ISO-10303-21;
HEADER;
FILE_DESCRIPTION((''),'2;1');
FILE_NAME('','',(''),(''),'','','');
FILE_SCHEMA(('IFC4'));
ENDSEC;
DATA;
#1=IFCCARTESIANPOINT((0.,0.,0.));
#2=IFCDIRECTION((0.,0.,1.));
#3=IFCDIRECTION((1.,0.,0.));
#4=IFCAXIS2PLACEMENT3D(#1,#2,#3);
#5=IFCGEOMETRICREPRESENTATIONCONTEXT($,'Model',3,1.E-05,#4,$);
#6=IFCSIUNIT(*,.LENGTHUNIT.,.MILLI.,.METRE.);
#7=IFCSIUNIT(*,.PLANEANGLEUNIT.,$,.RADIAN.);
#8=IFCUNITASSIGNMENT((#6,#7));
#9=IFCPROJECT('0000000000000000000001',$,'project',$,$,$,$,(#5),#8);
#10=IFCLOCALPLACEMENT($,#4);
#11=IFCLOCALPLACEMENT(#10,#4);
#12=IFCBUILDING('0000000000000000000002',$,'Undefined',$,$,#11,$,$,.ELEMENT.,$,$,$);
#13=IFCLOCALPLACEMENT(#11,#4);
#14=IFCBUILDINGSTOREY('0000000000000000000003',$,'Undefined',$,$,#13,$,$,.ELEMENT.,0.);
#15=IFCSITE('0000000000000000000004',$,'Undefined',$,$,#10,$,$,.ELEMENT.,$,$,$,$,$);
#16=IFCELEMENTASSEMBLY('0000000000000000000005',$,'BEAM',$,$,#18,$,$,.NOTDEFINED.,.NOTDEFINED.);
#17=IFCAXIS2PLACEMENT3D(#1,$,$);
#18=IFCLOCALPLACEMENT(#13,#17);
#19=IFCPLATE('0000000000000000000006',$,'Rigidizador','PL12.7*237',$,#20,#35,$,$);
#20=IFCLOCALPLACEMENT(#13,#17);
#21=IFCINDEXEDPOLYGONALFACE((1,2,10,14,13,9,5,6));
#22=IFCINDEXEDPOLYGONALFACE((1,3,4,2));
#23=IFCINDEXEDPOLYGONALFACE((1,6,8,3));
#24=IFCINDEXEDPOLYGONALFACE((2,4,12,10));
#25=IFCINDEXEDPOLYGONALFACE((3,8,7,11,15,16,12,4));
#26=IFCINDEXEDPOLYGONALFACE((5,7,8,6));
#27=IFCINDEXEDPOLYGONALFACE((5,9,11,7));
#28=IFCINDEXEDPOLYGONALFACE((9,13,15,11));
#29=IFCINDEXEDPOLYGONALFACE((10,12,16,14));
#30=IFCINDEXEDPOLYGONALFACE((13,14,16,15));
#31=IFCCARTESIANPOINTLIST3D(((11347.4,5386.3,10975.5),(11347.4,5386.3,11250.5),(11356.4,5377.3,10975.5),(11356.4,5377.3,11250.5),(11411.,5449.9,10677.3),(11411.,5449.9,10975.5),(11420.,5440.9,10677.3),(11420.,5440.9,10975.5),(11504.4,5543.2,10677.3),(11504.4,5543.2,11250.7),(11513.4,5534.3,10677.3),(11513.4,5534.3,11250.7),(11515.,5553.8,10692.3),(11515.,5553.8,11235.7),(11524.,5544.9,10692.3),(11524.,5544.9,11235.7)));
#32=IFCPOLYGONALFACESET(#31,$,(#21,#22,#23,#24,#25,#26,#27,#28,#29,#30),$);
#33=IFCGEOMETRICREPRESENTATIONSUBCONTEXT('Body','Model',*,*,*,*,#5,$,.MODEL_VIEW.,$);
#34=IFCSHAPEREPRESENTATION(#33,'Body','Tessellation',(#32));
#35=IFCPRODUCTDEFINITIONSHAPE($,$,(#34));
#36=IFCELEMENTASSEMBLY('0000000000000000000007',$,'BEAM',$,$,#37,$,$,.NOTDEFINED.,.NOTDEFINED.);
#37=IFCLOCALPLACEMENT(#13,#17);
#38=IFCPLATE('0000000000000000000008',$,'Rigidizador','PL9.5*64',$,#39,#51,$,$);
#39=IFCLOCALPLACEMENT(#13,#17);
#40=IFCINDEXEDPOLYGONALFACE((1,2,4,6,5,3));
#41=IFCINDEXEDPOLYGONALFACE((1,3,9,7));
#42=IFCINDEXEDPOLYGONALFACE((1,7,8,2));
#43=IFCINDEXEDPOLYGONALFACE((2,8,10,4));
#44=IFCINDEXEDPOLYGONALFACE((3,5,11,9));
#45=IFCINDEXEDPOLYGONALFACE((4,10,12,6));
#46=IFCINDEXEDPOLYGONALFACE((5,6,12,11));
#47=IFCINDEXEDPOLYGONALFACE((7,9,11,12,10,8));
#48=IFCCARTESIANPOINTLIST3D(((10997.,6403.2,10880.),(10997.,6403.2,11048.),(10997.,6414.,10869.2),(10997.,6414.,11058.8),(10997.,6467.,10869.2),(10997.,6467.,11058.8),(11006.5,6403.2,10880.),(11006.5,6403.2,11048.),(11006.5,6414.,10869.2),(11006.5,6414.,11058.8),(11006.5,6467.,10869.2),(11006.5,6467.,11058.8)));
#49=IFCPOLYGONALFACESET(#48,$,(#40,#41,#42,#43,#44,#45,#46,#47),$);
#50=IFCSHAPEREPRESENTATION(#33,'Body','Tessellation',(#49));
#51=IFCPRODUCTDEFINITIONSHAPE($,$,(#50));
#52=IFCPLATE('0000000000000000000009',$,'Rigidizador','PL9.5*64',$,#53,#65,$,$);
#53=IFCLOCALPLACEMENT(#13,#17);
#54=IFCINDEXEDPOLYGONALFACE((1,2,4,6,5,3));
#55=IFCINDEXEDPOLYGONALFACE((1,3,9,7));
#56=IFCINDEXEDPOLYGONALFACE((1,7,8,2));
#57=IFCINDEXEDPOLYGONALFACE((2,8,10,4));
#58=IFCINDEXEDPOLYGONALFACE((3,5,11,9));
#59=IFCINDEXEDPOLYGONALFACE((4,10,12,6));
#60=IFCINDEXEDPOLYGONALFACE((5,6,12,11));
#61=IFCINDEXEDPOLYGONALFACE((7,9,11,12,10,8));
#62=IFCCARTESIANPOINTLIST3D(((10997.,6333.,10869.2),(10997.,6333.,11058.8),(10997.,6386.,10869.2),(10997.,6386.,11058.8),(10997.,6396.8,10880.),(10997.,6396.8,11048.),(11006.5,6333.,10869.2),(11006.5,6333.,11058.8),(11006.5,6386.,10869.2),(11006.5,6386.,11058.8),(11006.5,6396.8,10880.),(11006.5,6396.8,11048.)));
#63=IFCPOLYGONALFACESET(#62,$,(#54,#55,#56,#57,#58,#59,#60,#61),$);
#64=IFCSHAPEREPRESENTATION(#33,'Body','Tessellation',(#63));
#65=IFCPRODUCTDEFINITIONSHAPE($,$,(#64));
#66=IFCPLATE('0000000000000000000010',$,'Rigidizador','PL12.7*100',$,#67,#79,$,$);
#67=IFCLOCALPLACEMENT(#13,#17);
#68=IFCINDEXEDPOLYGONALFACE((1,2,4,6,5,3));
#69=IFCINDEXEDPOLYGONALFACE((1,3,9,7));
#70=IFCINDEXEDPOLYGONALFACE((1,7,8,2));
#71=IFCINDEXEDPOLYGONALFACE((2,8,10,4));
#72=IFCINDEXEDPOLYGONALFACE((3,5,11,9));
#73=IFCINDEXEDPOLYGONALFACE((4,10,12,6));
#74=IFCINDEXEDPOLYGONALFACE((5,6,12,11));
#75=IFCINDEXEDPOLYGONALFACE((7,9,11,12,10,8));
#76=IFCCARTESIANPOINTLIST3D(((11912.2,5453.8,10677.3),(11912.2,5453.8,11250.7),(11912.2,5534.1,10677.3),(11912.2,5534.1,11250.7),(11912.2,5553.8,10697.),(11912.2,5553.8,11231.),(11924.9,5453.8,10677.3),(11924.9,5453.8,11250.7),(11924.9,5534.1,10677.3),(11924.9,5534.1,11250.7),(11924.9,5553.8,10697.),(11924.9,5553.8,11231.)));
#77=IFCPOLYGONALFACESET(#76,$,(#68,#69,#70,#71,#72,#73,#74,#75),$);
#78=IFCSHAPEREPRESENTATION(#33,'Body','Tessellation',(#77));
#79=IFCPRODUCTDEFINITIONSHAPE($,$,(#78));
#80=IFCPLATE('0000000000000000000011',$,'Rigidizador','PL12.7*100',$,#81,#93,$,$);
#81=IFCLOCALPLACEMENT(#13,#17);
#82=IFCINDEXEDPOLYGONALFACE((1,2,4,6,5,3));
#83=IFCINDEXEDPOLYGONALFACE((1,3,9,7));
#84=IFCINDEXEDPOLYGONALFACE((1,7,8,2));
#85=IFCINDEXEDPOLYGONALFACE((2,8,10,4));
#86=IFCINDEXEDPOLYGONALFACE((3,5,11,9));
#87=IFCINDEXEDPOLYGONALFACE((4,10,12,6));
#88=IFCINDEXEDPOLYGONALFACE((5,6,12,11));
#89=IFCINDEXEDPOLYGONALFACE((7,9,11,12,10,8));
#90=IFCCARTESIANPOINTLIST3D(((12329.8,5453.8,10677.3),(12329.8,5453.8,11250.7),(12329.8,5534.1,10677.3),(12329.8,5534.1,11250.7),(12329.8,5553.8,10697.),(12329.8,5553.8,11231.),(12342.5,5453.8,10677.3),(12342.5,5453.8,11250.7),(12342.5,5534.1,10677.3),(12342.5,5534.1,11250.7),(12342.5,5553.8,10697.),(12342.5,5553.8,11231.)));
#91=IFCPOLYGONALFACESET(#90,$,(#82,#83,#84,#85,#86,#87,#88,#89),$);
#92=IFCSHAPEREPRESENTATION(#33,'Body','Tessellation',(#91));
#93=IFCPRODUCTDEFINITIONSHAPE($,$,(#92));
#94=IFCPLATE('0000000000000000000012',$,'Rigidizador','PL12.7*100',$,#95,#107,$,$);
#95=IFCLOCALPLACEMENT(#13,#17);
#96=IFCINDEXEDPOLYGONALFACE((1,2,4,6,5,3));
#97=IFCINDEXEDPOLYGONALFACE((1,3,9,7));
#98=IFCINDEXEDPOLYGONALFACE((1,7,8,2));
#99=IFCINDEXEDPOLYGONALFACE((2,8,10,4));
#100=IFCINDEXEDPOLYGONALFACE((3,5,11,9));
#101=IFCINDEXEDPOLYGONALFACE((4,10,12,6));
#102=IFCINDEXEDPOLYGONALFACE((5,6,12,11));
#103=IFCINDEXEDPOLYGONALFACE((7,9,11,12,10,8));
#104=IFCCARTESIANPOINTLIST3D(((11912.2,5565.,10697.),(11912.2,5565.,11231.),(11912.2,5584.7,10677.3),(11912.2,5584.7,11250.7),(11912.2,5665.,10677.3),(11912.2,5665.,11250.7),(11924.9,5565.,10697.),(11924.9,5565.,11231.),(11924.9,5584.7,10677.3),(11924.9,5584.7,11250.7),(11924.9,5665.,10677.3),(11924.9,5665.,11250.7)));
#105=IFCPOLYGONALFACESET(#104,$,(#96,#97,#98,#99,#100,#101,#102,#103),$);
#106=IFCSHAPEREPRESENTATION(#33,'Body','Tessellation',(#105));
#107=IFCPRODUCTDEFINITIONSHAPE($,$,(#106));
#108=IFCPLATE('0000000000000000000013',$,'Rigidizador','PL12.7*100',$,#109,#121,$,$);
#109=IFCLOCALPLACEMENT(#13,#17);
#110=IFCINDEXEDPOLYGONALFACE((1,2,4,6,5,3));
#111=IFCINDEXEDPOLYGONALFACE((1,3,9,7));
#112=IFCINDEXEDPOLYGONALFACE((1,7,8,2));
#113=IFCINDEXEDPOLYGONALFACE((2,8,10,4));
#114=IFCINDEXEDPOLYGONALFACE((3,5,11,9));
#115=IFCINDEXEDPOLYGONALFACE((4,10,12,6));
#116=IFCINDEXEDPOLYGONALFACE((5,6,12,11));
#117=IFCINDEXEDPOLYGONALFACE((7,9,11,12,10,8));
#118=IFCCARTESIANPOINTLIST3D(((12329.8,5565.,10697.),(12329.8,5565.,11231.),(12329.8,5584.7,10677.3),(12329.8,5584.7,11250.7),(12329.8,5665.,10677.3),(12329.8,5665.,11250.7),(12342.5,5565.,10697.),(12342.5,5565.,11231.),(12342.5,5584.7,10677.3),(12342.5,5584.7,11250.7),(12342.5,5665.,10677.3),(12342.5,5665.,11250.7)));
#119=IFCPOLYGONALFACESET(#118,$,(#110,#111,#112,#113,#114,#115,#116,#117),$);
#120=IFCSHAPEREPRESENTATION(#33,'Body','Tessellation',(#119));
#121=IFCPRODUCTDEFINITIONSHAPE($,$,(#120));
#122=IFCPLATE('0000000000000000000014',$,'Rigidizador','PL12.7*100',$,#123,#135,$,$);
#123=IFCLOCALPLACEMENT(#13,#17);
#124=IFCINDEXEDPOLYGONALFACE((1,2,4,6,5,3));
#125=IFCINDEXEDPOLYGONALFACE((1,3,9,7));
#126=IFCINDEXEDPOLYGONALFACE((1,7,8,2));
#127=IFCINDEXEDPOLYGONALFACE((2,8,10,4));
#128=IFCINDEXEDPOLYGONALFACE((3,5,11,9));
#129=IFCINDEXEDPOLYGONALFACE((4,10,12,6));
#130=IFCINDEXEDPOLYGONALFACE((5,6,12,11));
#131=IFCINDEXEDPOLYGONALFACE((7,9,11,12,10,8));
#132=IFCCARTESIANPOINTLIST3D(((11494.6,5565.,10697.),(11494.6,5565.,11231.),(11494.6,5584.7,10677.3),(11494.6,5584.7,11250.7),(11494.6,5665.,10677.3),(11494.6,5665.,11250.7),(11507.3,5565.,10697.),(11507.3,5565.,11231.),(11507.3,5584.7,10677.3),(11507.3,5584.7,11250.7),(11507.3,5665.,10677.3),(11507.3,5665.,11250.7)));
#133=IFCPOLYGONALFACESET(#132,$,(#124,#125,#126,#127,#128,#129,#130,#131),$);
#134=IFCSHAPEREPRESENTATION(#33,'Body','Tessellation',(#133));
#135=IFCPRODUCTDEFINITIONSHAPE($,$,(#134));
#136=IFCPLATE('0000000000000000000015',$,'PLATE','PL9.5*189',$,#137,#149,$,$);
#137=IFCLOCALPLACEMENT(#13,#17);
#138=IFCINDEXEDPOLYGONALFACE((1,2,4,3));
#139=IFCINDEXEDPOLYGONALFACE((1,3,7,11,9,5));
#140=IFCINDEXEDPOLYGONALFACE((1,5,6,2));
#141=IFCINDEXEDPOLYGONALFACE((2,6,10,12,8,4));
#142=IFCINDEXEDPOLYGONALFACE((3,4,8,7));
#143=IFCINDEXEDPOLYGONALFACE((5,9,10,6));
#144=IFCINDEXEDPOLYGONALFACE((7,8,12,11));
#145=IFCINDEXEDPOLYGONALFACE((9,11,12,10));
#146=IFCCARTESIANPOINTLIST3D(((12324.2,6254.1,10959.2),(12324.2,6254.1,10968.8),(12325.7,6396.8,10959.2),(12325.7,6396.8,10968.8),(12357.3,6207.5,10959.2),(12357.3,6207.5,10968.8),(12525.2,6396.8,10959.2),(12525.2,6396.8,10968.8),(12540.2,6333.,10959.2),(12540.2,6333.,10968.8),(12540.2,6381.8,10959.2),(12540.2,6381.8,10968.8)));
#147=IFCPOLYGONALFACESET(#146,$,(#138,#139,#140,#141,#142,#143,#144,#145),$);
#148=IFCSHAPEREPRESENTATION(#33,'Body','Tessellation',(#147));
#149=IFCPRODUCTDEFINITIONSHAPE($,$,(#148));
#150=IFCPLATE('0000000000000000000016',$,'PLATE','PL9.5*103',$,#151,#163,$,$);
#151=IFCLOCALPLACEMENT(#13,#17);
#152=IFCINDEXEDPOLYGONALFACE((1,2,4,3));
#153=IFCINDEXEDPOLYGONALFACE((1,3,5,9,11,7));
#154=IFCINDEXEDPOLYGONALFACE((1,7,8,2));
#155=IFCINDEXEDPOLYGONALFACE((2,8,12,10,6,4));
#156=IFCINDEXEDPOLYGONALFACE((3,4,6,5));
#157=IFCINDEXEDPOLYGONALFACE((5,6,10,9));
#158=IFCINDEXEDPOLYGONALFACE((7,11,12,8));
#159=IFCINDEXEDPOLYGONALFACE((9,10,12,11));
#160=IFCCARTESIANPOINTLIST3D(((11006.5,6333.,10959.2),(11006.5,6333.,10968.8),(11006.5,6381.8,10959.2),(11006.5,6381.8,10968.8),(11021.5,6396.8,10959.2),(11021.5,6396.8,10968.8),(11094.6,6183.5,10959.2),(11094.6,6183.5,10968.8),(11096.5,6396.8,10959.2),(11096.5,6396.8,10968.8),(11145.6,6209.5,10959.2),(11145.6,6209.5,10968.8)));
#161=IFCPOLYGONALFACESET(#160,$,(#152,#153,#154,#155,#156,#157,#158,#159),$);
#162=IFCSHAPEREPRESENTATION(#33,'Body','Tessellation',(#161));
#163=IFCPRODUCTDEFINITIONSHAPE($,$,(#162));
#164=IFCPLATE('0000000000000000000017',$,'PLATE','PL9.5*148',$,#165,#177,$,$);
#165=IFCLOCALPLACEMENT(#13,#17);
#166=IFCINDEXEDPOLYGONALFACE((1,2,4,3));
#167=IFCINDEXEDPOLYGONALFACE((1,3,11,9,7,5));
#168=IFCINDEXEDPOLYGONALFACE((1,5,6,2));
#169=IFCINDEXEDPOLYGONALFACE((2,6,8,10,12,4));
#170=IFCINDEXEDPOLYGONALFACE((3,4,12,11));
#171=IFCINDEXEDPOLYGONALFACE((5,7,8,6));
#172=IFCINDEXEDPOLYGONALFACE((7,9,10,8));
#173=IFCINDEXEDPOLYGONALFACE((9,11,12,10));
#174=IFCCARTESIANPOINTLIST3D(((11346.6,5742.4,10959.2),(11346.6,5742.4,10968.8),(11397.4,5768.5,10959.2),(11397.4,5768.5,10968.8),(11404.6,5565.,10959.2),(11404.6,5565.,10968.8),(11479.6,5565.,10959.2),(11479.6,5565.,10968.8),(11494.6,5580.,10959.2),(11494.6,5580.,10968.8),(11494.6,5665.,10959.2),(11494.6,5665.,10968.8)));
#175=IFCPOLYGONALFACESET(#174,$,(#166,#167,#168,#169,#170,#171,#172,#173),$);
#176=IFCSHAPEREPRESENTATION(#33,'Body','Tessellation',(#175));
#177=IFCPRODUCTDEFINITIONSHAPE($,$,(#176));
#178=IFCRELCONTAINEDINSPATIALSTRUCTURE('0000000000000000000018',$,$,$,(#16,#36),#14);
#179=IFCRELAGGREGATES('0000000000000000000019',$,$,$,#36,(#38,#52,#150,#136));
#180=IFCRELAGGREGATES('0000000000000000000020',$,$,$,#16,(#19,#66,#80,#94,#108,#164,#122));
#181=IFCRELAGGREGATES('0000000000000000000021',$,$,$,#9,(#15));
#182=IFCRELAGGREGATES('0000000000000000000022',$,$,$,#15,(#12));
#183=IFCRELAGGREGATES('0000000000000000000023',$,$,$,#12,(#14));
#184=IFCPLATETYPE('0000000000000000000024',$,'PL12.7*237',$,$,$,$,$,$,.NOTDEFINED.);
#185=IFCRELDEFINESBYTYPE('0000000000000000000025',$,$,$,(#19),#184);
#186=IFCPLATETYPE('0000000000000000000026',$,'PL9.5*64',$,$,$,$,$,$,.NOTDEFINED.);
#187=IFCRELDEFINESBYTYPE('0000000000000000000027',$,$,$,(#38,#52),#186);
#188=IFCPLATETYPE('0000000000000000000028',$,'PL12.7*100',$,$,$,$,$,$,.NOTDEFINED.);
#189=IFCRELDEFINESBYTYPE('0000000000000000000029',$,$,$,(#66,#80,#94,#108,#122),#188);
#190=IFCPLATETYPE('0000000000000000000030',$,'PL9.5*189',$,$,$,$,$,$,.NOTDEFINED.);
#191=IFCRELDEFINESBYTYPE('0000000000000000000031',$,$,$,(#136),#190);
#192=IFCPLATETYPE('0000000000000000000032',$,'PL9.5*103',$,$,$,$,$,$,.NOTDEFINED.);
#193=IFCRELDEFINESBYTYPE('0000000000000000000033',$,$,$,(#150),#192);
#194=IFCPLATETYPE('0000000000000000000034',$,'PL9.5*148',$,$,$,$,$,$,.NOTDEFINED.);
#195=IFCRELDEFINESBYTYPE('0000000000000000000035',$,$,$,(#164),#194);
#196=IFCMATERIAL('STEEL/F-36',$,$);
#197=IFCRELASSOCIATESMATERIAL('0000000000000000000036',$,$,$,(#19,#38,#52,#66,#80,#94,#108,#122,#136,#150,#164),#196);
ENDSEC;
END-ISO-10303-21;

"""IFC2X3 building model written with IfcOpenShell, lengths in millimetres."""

from ifc_helpers import new_model, si_unit, frame, origin_with_axes, place, context, subcontext, project, spatial, polyline, outline, extrude, material, type_object, element, aggregate, save


model = new_model("IFC2X3")

# Units and contexts
model_context = context("Model", 3, precision=1e-05, world=origin_with_axes())
body_context = subcontext(model_context, "Body", "Model", "MODEL_VIEW")
ifc_project = project(units=[si_unit("LENGTHUNIT", "METRE", prefix="MILLI"), si_unit("PLANEANGLEUNIT", "RADIAN")], contexts=[model_context])

# Site, building, storey
site_placement = place(None, origin_with_axes())
site = spatial("IfcSite", under=ifc_project, at=site_placement, Name="Undefined", CompositionType="ELEMENT")
building_placement = place(site_placement, origin_with_axes())
building = spatial("IfcBuilding", under=site, at=building_placement, Name="Undefined", CompositionType="ELEMENT")
storey_placement = place(building_placement, origin_with_axes())
storey = spatial("IfcBuildingStorey", under=building, at=storey_placement, Name="Undefined", CompositionType="ELEMENT", Elevation=0.0)

# Element assembly, plate
ifc_material_1 = material(Name="STEEL/F-36")
assembly_1_placement = place(storey_placement, origin_with_axes())
assembly_1 = element("IfcElementAssembly", 1, at=assembly_1_placement, inside=storey, Name="BEAM", AssemblyPlace="NOTDEFINED", PredefinedType="NOTDEFINED")
plate_type_1 = type_object("IfcPlateType", Name="PL12.7*237", PredefinedType="NOTDEFINED")
plate_1_placement = place(assembly_1_placement, frame((11351.9, 5381.8, 11250.5), z_axis=(-0.707106, 0.707107, 0.0), x_axis=(0.707107, 0.707106, 0.000873)))
plate_1 = element("IfcPlate", 2, at=plate_1_placement, type_object=plate_type_1, material=ifc_material_1, Name="Rigidizador", Description="PL12.7*237", context=body_context, shape_type="SweptSolid", body=[
    extrude(outline(polyline([(0.0, 0.0), (222.0, 0.0), (237.0, 15.0), (236.5, 558.4), (221.5, 573.4), (89.5, 573.3), (89.8, 275.1), (-0.2, 275.0), (0.0, 0.0)])), frame((0.0, 0.0, -6.3), z_axis=(0.0, 0.0, 1.0), x_axis=(1.0, 0.0, 0.0)), (0.0, 0.0, 1.0), 12.7),
])

# Element assembly, plates
assembly_2_placement = place(storey_placement, origin_with_axes())
assembly_2 = element("IfcElementAssembly", 3, at=assembly_2_placement, inside=storey, Name="BEAM", AssemblyPlace="NOTDEFINED", PredefinedType="NOTDEFINED")
plate_type_2 = type_object("IfcPlateType", Name="PL9.5*64", PredefinedType="NOTDEFINED")
plate_2_placement = place(assembly_2_placement, frame((11001.7, 6467.0, 10869.2), z_axis=(-1.0, 0.0, 0.0), x_axis=(0.0, -1.0, 0.0)))
plate_2 = element("IfcPlate", 4, at=plate_2_placement, type_object=plate_type_2, material=ifc_material_1, Name="Rigidizador", Description="PL9.5*64", context=body_context, shape_type="SweptSolid", body=[
    extrude(outline(polyline([(0.0, 0.0), (53.0, 0.0), (63.8, 10.8), (63.8, 178.8), (53.0, 189.6), (0.0, 189.6), (0.0, 0.0)])), frame((0.0, 0.0, -4.8), z_axis=(0.0, 0.0, 1.0), x_axis=(1.0, 0.0, 0.0)), (0.0, 0.0, 1.0), 9.5),
])
plate_3_placement = place(assembly_2_placement, frame((11001.7, 6396.8, 10869.2), z_axis=(-1.0, 0.0, 0.0), x_axis=(0.0, -1.0, 0.0)))
plate_3 = element("IfcPlate", 5, at=plate_3_placement, type_object=plate_type_2, material=ifc_material_1, Name="Rigidizador", Description="PL9.5*64", context=body_context, shape_type="SweptSolid", body=[
    extrude(outline(polyline([(0.0, 10.8), (10.8, 0.0), (63.8, 0.0), (63.8, 189.6), (10.8, 189.6), (0.0, 178.8), (0.0, 10.8)])), frame((0.0, 0.0, -4.8), z_axis=(0.0, 0.0, 1.0), x_axis=(1.0, 0.0, 0.0)), (0.0, 0.0, 1.0), 9.5),
])

# Plates
plate_type_3 = type_object("IfcPlateType", Name="PL12.7*100", PredefinedType="NOTDEFINED")
plate_4_placement = place(assembly_1_placement, frame((11918.6, 5553.8, 10677.3), z_axis=(-1.0, 0.000002, 0.0), x_axis=(-0.000002, -1.0, 0.0)))
plate_4 = element("IfcPlate", 6, at=plate_4_placement, type_object=plate_type_3, material=ifc_material_1, Name="Rigidizador", Description="PL12.7*100", context=body_context, shape_type="SweptSolid", body=[
    extrude(outline(polyline([(0.0, 19.7), (19.7, 0.0), (100.0, 0.0), (100.0, 573.4), (19.7, 573.4), (0.0, 553.7), (0.0, 19.7)])), frame((0.0, 0.0, -6.3), z_axis=(0.0, 0.0, 1.0), x_axis=(1.0, 0.0, 0.0)), (0.0, 0.0, 1.0), 12.7),
])
plate_5_placement = place(assembly_1_placement, frame((12336.2, 5553.8, 10677.3), z_axis=(-1.0, 0.000002, 0.0), x_axis=(-0.000002, -1.0, 0.0)))
plate_5 = element("IfcPlate", 7, at=plate_5_placement, type_object=plate_type_3, material=ifc_material_1, Name="Rigidizador", Description="PL12.7*100", context=body_context, shape_type="SweptSolid", body=[
    extrude(outline(polyline([(0.0, 19.7), (19.7, 0.0), (100.0, 0.0), (100.0, 573.4), (19.7, 573.4), (0.0, 553.7), (0.0, 19.7)])), frame((0.0, 0.0, -6.3), z_axis=(0.0, 0.0, 1.0), x_axis=(1.0, 0.0, 0.0)), (0.0, 0.0, 1.0), 12.7),
])
plate_6_placement = place(assembly_1_placement, frame((11918.6, 5565.0, 10677.3), z_axis=(1.0, 0.000002, 0.0), x_axis=(-0.000002, 1.0, 0.0)))
plate_6 = element("IfcPlate", 8, at=plate_6_placement, type_object=plate_type_3, material=ifc_material_1, Name="Rigidizador", Description="PL12.7*100", context=body_context, shape_type="SweptSolid", body=[
    extrude(outline(polyline([(0.0, 19.7), (19.7, 0.0), (100.0, 0.0), (100.0, 573.4), (19.7, 573.4), (0.0, 553.7), (0.0, 19.7)])), frame((0.0, 0.0, -6.3), z_axis=(0.0, 0.0, 1.0), x_axis=(1.0, 0.0, 0.0)), (0.0, 0.0, 1.0), 12.7),
])
plate_7_placement = place(assembly_1_placement, frame((12336.2, 5565.0, 10677.3), z_axis=(1.0, 0.000002, 0.0), x_axis=(-0.000002, 1.0, 0.0)))
plate_7 = element("IfcPlate", 9, at=plate_7_placement, type_object=plate_type_3, material=ifc_material_1, Name="Rigidizador", Description="PL12.7*100", context=body_context, shape_type="SweptSolid", body=[
    extrude(outline(polyline([(0.0, 19.7), (19.7, 0.0), (100.0, 0.0), (100.0, 573.4), (19.7, 573.4), (0.0, 553.7), (0.0, 19.7)])), frame((0.0, 0.0, -6.3), z_axis=(0.0, 0.0, 1.0), x_axis=(1.0, 0.0, 0.0)), (0.0, 0.0, 1.0), 12.7),
])
plate_8_placement = place(assembly_1_placement, frame((11501.0, 5565.0, 10677.3), z_axis=(1.0, -0.000002, 0.0), x_axis=(0.000002, 1.0, 0.0)))
plate_8 = element("IfcPlate", 10, at=plate_8_placement, type_object=plate_type_3, material=ifc_material_1, Name="Rigidizador", Description="PL12.7*100", context=body_context, shape_type="SweptSolid", body=[
    extrude(outline(polyline([(0.0, 19.7), (19.7, 0.0), (100.0, 0.0), (100.0, 573.4), (19.7, 573.4), (0.0, 553.7), (0.0, 19.7)])), frame((0.0, 0.0, -6.3), z_axis=(0.0, 0.0, 1.0), x_axis=(1.0, 0.0, 0.0)), (0.0, 0.0, 1.0), 12.7),
])
plate_type_4 = type_object("IfcPlateType", Name="PL9.5*189", PredefinedType="NOTDEFINED")
plate_9_placement = place(assembly_2_placement, frame((12357.3, 6207.5, 10964.0), z_axis=(0.0, 0.0, -1.0), x_axis=(-0.578681, 0.815554, 0.0)))
plate_9 = element("IfcPlate", 11, at=plate_9_placement, type_object=plate_type_4, material=ifc_material_1, Name="PLATE", Description="PL9.5*189", context=body_context, shape_type="SweptSolid", body=[
    extrude(outline(polyline([(0.0, 0.0), (57.2, 0.0), (172.7, 83.8), (57.2, 246.5), (36.3, 250.1), (-3.5, 221.9), (0.0, 0.0)])), frame((0.0, 0.0, -4.8), z_axis=(0.0, 0.0, 1.0), x_axis=(1.0, 0.0, 0.0)), (0.0, 0.0, 1.0), 9.5),
])
plate_type_5 = type_object("IfcPlateType", Name="PL9.5*103", PredefinedType="NOTDEFINED")
plate_10_placement = place(assembly_2_placement, frame((11006.5, 6396.8, 10964.0), z_axis=(0.0, 0.0, -1.0), x_axis=(1.0, 0.0, 0.0)))
plate_10 = element("IfcPlate", 12, at=plate_10_placement, type_object=plate_type_5, material=ifc_material_1, Name="PLATE", Description="PL9.5*103", context=body_context, shape_type="SweptSolid", body=[
    extrude(outline(polyline([(0.0, 15.0), (15.0, 0.0), (90.0, 0.0), (139.1, 187.3), (88.1, 213.3), (0.0, 63.8), (0.0, 15.0)])), frame((0.0, 0.0, -4.8), z_axis=(0.0, 0.0, 1.0), x_axis=(1.0, 0.0, 0.0)), (0.0, 0.0, 1.0), 9.5),
])
plate_type_6 = type_object("IfcPlateType", Name="PL9.5*148", PredefinedType="NOTDEFINED")
plate_11_placement = place(assembly_1_placement, frame((11494.6, 5665.0, 10964.0), z_axis=(0.0, 0.0, -1.0), x_axis=(-0.000002, -1.0, 0.0)))
plate_11 = element("IfcPlate", 13, at=plate_11_placement, type_object=plate_type_6, material=ifc_material_1, Name="PLATE", Description="PL9.5*148", context=body_context, shape_type="SweptSolid", body=[
    extrude(outline(polyline([(0.0, 0.0), (85.0, 0.0), (100.0, 15.0), (100.0, 90.0), (-77.4, 148.0), (-103.5, 97.2), (0.0, 0.0)])), frame((0.0, 0.0, -4.8), z_axis=(0.0, 0.0, 1.0), x_axis=(1.0, 0.0, 0.0)), (0.0, 0.0, 1.0), 9.5),
])
aggregate(assembly_2, [plate_2, plate_3, plate_10, plate_9])

aggregate(assembly_1, [plate_1, plate_4, plate_5, plate_6, plate_7, plate_11, plate_8])

save(model, "model.ifc")
